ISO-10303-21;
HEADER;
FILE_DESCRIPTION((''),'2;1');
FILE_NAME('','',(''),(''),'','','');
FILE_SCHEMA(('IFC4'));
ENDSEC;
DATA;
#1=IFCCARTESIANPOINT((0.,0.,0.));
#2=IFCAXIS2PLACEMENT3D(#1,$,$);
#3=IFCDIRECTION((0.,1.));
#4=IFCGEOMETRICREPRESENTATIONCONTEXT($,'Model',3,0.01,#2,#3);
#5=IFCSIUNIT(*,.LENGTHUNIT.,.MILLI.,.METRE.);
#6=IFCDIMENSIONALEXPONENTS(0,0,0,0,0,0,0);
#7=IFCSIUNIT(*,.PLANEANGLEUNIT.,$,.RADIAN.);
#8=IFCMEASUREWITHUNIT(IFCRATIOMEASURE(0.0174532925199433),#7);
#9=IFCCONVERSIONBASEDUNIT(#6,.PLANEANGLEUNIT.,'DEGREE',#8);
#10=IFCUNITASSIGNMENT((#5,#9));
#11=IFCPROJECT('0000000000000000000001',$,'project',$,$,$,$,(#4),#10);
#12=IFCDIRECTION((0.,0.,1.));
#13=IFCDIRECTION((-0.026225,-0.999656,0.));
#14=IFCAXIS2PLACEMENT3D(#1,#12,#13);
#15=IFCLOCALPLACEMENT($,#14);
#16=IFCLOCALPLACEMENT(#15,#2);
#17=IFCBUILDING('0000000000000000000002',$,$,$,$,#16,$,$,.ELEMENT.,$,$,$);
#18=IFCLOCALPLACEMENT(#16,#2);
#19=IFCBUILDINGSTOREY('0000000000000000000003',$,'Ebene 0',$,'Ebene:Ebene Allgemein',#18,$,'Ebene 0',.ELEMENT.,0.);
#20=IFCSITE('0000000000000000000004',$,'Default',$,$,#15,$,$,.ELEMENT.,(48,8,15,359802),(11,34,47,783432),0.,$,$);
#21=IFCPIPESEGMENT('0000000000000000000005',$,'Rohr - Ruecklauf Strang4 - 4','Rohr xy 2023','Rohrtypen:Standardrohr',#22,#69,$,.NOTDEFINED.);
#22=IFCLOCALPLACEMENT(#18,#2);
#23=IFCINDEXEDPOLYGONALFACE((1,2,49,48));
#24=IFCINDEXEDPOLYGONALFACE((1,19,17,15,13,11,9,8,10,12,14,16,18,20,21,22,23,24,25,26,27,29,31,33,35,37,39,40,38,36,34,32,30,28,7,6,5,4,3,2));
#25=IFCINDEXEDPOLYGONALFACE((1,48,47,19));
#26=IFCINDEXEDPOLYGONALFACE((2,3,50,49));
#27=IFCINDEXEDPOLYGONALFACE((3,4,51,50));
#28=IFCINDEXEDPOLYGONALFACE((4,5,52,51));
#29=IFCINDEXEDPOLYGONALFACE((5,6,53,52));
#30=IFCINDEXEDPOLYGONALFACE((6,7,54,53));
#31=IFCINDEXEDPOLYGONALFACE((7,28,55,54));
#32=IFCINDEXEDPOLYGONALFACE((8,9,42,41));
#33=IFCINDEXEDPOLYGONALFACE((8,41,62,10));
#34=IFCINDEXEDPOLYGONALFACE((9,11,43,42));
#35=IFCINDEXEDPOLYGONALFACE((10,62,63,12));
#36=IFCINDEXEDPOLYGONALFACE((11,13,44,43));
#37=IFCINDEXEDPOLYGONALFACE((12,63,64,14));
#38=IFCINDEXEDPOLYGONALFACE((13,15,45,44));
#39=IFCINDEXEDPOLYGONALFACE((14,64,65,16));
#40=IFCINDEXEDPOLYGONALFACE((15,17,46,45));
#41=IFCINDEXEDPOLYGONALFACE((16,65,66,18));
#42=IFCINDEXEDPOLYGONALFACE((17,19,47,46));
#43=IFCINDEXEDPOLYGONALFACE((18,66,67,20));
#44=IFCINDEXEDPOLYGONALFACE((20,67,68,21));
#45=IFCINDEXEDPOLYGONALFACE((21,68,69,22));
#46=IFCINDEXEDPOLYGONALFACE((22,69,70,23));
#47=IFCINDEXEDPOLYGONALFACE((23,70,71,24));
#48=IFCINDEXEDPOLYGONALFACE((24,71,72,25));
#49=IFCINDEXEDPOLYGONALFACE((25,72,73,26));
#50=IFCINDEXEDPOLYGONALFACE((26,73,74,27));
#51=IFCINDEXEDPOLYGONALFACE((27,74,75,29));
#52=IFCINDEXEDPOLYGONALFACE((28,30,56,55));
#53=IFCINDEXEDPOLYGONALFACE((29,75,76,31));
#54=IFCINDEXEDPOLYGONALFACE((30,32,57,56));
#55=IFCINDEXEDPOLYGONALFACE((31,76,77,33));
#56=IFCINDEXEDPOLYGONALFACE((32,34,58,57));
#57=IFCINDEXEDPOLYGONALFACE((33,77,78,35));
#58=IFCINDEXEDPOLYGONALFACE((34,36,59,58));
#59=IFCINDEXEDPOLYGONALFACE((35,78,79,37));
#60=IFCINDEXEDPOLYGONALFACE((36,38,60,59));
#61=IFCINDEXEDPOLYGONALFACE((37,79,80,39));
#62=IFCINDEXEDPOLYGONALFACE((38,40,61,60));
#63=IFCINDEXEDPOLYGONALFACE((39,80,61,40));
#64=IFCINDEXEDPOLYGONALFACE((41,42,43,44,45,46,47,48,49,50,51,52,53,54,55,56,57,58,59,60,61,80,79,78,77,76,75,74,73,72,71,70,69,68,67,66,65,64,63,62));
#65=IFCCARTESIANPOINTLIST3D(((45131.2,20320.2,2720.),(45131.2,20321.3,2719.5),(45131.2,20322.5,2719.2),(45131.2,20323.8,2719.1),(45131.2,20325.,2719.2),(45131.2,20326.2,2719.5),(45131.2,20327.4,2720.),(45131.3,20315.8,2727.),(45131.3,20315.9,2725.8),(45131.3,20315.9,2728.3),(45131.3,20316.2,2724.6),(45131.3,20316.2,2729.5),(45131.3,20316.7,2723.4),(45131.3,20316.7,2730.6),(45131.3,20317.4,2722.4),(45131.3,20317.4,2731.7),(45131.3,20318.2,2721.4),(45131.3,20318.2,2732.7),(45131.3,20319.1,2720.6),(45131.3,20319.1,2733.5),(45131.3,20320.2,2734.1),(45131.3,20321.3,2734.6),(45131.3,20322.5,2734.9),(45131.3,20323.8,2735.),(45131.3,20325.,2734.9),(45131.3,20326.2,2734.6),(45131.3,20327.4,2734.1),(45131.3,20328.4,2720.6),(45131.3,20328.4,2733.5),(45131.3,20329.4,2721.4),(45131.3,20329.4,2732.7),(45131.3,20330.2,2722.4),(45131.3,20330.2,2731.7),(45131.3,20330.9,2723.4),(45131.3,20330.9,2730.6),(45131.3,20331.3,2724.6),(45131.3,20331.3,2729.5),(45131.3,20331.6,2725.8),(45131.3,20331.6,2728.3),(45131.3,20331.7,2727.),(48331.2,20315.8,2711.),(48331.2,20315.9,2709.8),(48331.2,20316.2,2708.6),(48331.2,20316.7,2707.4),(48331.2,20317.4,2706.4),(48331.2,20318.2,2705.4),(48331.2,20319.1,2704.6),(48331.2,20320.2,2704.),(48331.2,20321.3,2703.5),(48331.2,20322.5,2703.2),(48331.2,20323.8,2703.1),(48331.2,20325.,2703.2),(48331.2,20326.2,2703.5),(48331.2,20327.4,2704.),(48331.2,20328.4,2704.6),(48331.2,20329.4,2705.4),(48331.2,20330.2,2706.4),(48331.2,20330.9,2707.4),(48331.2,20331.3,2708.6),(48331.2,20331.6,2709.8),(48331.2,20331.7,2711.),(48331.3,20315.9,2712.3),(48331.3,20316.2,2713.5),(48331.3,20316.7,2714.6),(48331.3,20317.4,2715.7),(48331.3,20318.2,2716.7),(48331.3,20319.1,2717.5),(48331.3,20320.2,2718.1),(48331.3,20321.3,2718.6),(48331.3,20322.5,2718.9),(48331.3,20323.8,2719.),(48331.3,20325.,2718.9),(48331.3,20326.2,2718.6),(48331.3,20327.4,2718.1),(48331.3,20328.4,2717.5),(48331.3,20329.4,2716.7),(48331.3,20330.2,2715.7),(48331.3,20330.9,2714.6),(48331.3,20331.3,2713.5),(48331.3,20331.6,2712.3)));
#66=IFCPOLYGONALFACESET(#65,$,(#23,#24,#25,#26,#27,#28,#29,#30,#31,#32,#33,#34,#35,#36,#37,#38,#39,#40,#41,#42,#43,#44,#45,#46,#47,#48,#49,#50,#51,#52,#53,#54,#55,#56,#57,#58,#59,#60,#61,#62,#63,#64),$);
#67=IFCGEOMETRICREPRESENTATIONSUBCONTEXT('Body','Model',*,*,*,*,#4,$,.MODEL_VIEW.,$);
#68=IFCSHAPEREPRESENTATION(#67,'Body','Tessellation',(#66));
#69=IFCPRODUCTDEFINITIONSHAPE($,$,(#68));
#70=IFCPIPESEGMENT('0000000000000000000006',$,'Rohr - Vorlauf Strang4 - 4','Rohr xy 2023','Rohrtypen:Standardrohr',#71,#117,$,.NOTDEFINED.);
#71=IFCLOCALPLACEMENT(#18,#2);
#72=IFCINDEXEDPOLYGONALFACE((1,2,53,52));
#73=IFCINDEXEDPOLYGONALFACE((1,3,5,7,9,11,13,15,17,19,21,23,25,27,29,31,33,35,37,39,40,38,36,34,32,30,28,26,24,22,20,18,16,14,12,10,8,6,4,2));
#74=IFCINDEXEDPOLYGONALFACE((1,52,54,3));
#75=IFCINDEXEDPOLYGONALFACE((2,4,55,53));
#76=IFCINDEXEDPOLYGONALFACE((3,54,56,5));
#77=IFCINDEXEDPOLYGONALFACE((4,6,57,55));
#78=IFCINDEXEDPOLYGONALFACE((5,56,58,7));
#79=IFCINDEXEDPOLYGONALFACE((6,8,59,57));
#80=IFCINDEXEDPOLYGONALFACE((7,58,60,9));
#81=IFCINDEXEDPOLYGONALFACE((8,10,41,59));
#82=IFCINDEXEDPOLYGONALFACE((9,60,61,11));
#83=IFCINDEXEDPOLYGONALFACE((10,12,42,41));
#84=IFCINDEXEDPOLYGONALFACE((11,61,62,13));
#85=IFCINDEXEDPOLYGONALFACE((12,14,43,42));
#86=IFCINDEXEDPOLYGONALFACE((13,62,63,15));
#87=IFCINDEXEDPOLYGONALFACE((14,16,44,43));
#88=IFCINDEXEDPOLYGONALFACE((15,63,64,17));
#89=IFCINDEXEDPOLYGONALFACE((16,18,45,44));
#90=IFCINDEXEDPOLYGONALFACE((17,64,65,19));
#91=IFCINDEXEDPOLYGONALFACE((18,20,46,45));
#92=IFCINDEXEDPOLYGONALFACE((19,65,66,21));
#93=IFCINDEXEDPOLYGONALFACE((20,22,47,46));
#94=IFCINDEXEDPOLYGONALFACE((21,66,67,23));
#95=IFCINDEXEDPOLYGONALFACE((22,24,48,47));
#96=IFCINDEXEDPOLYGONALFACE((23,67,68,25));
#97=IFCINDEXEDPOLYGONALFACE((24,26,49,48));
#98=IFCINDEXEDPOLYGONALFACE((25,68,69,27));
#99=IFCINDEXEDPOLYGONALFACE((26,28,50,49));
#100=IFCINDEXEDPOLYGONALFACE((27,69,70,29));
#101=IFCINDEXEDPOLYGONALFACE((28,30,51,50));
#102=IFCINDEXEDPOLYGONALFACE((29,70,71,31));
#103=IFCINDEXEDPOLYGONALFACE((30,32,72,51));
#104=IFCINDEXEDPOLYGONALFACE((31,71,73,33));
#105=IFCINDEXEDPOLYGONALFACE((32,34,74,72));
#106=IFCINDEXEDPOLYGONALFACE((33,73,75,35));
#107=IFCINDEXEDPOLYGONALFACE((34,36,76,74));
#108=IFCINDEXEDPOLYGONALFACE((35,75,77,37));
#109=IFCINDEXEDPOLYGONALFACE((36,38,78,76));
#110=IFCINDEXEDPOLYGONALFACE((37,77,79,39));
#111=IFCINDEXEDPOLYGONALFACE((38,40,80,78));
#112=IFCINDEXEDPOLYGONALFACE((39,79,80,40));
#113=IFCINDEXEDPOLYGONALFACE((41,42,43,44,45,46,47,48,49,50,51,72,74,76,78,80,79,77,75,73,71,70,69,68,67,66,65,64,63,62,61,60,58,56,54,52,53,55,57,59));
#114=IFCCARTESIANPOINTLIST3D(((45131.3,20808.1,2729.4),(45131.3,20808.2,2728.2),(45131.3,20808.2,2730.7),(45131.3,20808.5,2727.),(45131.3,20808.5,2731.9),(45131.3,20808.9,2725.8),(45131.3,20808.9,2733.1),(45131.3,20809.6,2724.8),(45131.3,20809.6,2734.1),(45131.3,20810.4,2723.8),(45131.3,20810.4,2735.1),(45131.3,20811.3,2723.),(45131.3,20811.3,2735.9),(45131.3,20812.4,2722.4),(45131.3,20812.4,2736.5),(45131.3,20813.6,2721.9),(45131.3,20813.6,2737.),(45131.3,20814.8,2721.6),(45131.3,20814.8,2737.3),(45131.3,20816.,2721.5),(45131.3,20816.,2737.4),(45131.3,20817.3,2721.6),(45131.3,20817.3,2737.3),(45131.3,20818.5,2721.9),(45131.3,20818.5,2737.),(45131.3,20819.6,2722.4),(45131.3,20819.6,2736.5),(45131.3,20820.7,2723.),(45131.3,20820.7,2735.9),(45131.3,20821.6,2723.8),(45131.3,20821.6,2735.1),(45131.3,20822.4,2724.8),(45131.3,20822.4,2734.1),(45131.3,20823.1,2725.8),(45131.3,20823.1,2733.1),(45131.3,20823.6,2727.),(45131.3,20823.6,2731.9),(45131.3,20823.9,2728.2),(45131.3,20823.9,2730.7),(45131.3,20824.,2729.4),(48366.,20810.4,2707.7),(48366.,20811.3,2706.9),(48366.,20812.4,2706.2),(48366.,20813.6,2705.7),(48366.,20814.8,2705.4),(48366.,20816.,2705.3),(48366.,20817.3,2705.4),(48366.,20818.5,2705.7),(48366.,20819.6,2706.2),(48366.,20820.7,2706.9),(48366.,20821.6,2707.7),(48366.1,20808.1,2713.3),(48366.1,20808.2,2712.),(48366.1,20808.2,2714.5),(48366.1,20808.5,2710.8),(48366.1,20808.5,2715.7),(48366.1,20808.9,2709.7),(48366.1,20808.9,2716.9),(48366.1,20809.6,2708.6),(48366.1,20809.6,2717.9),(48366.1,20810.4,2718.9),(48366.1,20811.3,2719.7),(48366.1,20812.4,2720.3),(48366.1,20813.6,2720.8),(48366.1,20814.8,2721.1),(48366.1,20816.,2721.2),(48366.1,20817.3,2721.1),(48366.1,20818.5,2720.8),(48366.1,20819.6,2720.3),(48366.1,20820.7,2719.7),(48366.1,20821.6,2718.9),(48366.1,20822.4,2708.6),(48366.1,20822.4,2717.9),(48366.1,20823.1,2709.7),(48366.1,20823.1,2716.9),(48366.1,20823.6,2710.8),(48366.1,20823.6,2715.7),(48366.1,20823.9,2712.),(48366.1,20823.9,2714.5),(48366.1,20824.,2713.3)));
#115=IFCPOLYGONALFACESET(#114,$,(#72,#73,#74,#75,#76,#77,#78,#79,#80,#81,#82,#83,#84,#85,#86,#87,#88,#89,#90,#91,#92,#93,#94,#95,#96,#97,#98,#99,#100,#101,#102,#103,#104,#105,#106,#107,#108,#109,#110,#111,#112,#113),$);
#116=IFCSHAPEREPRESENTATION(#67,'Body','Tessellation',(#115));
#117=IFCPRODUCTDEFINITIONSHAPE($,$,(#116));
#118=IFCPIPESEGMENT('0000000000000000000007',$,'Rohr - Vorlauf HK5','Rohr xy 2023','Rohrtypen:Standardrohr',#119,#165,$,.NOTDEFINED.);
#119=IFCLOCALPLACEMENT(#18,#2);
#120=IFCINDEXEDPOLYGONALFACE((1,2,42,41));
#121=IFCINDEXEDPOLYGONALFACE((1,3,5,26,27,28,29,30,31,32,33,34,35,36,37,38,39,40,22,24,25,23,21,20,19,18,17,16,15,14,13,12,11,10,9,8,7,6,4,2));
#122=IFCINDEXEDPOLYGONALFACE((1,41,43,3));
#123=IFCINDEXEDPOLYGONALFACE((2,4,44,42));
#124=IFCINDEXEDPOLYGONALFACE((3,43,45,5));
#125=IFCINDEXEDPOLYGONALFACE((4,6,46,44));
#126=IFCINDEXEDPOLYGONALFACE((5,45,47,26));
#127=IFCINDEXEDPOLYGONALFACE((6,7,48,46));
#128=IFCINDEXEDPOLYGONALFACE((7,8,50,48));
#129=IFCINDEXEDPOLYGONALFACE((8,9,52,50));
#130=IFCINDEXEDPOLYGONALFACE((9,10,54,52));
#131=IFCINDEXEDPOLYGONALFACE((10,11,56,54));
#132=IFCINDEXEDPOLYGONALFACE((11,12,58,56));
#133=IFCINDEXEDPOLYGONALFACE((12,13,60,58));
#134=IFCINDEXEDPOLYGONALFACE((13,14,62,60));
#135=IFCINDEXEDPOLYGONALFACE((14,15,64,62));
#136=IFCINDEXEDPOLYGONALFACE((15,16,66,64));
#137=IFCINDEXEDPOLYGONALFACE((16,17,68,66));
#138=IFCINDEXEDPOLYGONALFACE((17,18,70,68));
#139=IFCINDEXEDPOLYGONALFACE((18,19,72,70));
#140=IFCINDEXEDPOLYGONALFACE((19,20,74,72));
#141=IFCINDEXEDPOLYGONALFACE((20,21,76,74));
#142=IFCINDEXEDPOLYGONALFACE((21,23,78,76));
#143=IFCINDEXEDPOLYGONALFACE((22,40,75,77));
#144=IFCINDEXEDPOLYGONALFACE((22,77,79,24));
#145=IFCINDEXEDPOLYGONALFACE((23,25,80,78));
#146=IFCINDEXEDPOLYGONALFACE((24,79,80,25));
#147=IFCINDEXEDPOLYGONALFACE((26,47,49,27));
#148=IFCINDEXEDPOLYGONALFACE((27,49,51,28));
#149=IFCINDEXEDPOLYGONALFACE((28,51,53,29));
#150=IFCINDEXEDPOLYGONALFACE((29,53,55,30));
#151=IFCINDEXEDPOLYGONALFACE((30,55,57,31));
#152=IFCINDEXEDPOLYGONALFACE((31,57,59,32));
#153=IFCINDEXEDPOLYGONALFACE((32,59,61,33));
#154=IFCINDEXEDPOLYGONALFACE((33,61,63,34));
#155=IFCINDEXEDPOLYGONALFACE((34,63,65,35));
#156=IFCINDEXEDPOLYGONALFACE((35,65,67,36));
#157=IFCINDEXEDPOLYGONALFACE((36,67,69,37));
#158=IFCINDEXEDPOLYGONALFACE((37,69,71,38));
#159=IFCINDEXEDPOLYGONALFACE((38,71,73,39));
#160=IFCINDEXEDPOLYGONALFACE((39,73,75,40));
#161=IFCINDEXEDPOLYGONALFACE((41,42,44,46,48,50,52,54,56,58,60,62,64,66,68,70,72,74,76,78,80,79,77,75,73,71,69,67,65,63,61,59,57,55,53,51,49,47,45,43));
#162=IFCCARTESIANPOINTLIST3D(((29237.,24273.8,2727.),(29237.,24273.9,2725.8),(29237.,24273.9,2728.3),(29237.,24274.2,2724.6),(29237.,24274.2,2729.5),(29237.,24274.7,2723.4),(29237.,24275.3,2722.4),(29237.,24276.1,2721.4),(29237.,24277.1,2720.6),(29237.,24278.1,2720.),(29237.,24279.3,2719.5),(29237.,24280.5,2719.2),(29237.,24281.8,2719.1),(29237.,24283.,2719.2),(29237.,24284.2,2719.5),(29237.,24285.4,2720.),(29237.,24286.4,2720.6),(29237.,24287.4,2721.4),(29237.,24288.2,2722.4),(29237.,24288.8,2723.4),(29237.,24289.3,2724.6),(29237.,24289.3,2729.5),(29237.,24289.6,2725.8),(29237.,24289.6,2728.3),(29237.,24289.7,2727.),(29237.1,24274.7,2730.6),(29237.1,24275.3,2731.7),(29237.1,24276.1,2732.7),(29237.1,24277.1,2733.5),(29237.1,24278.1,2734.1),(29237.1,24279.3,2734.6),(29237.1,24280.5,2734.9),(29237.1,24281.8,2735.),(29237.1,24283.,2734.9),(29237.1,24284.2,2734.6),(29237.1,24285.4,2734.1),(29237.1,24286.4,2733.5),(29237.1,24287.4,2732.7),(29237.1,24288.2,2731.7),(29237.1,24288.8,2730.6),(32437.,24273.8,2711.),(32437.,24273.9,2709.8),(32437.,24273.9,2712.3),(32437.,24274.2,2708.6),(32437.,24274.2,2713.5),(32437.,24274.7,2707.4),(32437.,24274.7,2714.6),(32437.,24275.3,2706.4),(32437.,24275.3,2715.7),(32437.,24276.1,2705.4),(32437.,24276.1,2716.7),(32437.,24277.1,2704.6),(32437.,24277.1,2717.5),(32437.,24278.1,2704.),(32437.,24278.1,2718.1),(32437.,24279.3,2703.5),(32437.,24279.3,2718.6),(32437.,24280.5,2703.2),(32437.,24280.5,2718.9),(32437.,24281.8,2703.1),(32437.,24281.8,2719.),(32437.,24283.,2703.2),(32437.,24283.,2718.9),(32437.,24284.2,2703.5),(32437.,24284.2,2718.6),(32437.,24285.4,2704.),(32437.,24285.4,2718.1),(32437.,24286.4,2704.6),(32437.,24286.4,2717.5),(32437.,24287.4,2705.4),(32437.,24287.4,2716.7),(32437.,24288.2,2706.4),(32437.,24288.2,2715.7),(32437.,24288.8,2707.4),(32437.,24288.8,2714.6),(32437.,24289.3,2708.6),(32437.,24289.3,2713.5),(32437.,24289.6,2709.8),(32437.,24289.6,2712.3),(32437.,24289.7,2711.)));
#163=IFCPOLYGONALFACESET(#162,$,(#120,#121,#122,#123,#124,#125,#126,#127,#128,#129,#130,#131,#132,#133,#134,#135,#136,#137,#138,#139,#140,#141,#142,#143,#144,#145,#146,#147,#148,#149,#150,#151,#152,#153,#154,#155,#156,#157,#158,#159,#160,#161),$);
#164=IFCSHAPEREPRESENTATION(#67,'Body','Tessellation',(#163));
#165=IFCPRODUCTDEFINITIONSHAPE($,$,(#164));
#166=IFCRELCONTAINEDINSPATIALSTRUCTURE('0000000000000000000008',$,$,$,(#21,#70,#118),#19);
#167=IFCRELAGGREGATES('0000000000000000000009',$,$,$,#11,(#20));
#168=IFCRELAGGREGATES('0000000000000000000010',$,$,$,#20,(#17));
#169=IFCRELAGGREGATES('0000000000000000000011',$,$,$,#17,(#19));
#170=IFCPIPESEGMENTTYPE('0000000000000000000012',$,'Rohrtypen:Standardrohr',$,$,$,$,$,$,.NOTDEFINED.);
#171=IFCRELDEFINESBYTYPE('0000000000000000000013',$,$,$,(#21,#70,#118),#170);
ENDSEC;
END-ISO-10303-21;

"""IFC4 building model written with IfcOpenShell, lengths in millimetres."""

from ifc_helpers import new_model, entity, si_unit, converted_unit, direction, frame, origin, place, context, subcontext, project, spatial, indexed_curve, outline, extrude, type_object, element, save


model = new_model("IFC4")

# Units and contexts
model_context = context("Model", 3, precision=0.01, world=origin(), true_north=direction((0.0, 1.0)))
body_context = subcontext(model_context, "Body", "Model", "MODEL_VIEW")
ifc_project = project(units=[si_unit("LENGTHUNIT", "METRE", prefix="MILLI"), converted_unit("PLANEANGLEUNIT", "DEGREE", entity("IfcRatioMeasure", 0.0174532925199433), si_unit("PLANEANGLEUNIT", "RADIAN"), dimensions=[0, 0, 0, 0, 0, 0, 0])], contexts=[model_context])

# Site, building, storey
site_placement = place(None, frame((0.0, 0.0, 0.0), z_axis=(0.0, 0.0, 1.0), x_axis=(-0.026225, -0.999656, 0.0)))
site = spatial("IfcSite", under=ifc_project, at=site_placement, Name="Default", CompositionType="ELEMENT", RefLatitude=(48, 8, 15, 359802), RefLongitude=(11, 34, 47, 783432), RefElevation=0.0)
building_placement = place(site_placement, origin())
building = spatial("IfcBuilding", under=site, at=building_placement, CompositionType="ELEMENT")
storey_placement = place(building_placement, origin())
storey = spatial("IfcBuildingStorey", under=building, at=storey_placement, Name="Ebene 0", ObjectType="Ebene:Ebene Allgemein", LongName="Ebene 0", CompositionType="ELEMENT", Elevation=0.0)

# Pipe segments
pipe_segment_type = type_object("IfcPipeSegmentType", Name="Rohrtypen:Standardrohr", PredefinedType="NOTDEFINED")
pipe_segment_1_placement = place(storey_placement, origin())
element("IfcPipeSegment", 1, at=pipe_segment_1_placement, inside=storey, type_object=pipe_segment_type, Name="Rohr - Ruecklauf Strang4 - 4", Description="Rohr xy 2023", ObjectType="Rohrtypen:Standardrohr", PredefinedType="NOTDEFINED", context=body_context, shape_type="SweptSolid", body=[
    extrude(outline(indexed_curve([(7.9, 0.0), (7.8, 1.2), (7.6, 2.5), (7.1, 3.6), (6.4, 4.7), (5.6, 5.6), (4.7, 6.4), (3.6, 7.1), (2.5, 7.6), (1.2, 7.8), (0.0, 7.9), (-1.2, 7.8), (-2.5, 7.6), (-3.6, 7.1), (-4.7, 6.4), (-5.6, 5.6), (-6.4, 4.7), (-7.1, 3.6), (-7.6, 2.5), (-7.8, 1.2), (-7.9, 0.0), (-7.8, -1.2), (-7.6, -2.5), (-7.1, -3.6), (-6.4, -4.7), (-5.6, -5.6), (-4.7, -6.4), (-3.6, -7.1), (-2.5, -7.6), (-1.2, -7.8), (0.0, -7.9), (1.2, -7.8), (2.5, -7.6), (3.6, -7.1), (4.7, -6.4), (5.6, -5.6), (6.4, -4.7), (7.1, -3.6), (7.6, -2.5), (7.8, -1.2), (7.9, 0.0)], self_intersect=False)), frame((48331.2, 20323.8, 2711.0), z_axis=(-0.999988, 0.0, 0.005), x_axis=(0.0, 1.0, 0.0)), (0.0, 0.0, 1.0), 3200.0),
])
pipe_segment_2_placement = place(storey_placement, origin())
element("IfcPipeSegment", 2, at=pipe_segment_2_placement, inside=storey, type_object=pipe_segment_type, Name="Rohr - Vorlauf Strang4 - 4", Description="Rohr xy 2023", ObjectType="Rohrtypen:Standardrohr", PredefinedType="NOTDEFINED", context=body_context, shape_type="SweptSolid", body=[
    extrude(outline(indexed_curve([(7.9, 0.0), (7.8, 1.2), (7.6, 2.5), (7.1, 3.6), (6.4, 4.7), (5.6, 5.6), (4.7, 6.4), (3.6, 7.1), (2.5, 7.6), (1.2, 7.8), (0.0, 7.9), (-1.2, 7.8), (-2.5, 7.6), (-3.6, 7.1), (-4.7, 6.4), (-5.6, 5.6), (-6.4, 4.7), (-7.1, 3.6), (-7.6, 2.5), (-7.8, 1.2), (-7.9, 0.0), (-7.8, -1.2), (-7.6, -2.5), (-7.1, -3.6), (-6.4, -4.7), (-5.6, -5.6), (-4.7, -6.4), (-3.6, -7.1), (-2.5, -7.6), (-1.2, -7.8), (0.0, -7.9), (1.2, -7.8), (2.5, -7.6), (3.6, -7.1), (4.7, -6.4), (5.6, -5.6), (6.4, -4.7), (7.1, -3.6), (7.6, -2.5), (7.8, -1.2), (7.9, 0.0)], self_intersect=False)), frame((48366.1, 20816.0, 2713.3), z_axis=(-0.999988, 0.0, 0.005), x_axis=(0.0, 1.0, 0.0)), (0.0, 0.0, 1.0), 3234.8),
])
pipe_segment_3_placement = place(storey_placement, origin())
element("IfcPipeSegment", 3, at=pipe_segment_3_placement, inside=storey, type_object=pipe_segment_type, Name="Rohr - Vorlauf HK5", Description="Rohr xy 2023", ObjectType="Rohrtypen:Standardrohr", PredefinedType="NOTDEFINED", context=body_context, shape_type="SweptSolid", body=[
    extrude(outline(indexed_curve([(7.9, 0.0), (7.8, 1.2), (7.6, 2.5), (7.1, 3.6), (6.4, 4.7), (5.6, 5.6), (4.7, 6.4), (3.6, 7.1), (2.5, 7.6), (1.2, 7.8), (0.0, 7.9), (-1.2, 7.8), (-2.5, 7.6), (-3.6, 7.1), (-4.7, 6.4), (-5.6, 5.6), (-6.4, 4.7), (-7.1, 3.6), (-7.6, 2.5), (-7.8, 1.2), (-7.9, 0.0), (-7.8, -1.2), (-7.6, -2.5), (-7.1, -3.6), (-6.4, -4.7), (-5.6, -5.6), (-4.7, -6.4), (-3.6, -7.1), (-2.5, -7.6), (-1.2, -7.8), (0.0, -7.9), (1.2, -7.8), (2.5, -7.6), (3.6, -7.1), (4.7, -6.4), (5.6, -5.6), (6.4, -4.7), (7.1, -3.6), (7.6, -2.5), (7.8, -1.2), (7.9, 0.0)], self_intersect=False)), frame((32437.0, 24281.8, 2711.0), z_axis=(-0.999988, 0.0, 0.005), x_axis=(0.0, 1.0, 0.0)), (0.0, 0.0, 1.0), 3200.0),
])

save(model, "model.ifc")
